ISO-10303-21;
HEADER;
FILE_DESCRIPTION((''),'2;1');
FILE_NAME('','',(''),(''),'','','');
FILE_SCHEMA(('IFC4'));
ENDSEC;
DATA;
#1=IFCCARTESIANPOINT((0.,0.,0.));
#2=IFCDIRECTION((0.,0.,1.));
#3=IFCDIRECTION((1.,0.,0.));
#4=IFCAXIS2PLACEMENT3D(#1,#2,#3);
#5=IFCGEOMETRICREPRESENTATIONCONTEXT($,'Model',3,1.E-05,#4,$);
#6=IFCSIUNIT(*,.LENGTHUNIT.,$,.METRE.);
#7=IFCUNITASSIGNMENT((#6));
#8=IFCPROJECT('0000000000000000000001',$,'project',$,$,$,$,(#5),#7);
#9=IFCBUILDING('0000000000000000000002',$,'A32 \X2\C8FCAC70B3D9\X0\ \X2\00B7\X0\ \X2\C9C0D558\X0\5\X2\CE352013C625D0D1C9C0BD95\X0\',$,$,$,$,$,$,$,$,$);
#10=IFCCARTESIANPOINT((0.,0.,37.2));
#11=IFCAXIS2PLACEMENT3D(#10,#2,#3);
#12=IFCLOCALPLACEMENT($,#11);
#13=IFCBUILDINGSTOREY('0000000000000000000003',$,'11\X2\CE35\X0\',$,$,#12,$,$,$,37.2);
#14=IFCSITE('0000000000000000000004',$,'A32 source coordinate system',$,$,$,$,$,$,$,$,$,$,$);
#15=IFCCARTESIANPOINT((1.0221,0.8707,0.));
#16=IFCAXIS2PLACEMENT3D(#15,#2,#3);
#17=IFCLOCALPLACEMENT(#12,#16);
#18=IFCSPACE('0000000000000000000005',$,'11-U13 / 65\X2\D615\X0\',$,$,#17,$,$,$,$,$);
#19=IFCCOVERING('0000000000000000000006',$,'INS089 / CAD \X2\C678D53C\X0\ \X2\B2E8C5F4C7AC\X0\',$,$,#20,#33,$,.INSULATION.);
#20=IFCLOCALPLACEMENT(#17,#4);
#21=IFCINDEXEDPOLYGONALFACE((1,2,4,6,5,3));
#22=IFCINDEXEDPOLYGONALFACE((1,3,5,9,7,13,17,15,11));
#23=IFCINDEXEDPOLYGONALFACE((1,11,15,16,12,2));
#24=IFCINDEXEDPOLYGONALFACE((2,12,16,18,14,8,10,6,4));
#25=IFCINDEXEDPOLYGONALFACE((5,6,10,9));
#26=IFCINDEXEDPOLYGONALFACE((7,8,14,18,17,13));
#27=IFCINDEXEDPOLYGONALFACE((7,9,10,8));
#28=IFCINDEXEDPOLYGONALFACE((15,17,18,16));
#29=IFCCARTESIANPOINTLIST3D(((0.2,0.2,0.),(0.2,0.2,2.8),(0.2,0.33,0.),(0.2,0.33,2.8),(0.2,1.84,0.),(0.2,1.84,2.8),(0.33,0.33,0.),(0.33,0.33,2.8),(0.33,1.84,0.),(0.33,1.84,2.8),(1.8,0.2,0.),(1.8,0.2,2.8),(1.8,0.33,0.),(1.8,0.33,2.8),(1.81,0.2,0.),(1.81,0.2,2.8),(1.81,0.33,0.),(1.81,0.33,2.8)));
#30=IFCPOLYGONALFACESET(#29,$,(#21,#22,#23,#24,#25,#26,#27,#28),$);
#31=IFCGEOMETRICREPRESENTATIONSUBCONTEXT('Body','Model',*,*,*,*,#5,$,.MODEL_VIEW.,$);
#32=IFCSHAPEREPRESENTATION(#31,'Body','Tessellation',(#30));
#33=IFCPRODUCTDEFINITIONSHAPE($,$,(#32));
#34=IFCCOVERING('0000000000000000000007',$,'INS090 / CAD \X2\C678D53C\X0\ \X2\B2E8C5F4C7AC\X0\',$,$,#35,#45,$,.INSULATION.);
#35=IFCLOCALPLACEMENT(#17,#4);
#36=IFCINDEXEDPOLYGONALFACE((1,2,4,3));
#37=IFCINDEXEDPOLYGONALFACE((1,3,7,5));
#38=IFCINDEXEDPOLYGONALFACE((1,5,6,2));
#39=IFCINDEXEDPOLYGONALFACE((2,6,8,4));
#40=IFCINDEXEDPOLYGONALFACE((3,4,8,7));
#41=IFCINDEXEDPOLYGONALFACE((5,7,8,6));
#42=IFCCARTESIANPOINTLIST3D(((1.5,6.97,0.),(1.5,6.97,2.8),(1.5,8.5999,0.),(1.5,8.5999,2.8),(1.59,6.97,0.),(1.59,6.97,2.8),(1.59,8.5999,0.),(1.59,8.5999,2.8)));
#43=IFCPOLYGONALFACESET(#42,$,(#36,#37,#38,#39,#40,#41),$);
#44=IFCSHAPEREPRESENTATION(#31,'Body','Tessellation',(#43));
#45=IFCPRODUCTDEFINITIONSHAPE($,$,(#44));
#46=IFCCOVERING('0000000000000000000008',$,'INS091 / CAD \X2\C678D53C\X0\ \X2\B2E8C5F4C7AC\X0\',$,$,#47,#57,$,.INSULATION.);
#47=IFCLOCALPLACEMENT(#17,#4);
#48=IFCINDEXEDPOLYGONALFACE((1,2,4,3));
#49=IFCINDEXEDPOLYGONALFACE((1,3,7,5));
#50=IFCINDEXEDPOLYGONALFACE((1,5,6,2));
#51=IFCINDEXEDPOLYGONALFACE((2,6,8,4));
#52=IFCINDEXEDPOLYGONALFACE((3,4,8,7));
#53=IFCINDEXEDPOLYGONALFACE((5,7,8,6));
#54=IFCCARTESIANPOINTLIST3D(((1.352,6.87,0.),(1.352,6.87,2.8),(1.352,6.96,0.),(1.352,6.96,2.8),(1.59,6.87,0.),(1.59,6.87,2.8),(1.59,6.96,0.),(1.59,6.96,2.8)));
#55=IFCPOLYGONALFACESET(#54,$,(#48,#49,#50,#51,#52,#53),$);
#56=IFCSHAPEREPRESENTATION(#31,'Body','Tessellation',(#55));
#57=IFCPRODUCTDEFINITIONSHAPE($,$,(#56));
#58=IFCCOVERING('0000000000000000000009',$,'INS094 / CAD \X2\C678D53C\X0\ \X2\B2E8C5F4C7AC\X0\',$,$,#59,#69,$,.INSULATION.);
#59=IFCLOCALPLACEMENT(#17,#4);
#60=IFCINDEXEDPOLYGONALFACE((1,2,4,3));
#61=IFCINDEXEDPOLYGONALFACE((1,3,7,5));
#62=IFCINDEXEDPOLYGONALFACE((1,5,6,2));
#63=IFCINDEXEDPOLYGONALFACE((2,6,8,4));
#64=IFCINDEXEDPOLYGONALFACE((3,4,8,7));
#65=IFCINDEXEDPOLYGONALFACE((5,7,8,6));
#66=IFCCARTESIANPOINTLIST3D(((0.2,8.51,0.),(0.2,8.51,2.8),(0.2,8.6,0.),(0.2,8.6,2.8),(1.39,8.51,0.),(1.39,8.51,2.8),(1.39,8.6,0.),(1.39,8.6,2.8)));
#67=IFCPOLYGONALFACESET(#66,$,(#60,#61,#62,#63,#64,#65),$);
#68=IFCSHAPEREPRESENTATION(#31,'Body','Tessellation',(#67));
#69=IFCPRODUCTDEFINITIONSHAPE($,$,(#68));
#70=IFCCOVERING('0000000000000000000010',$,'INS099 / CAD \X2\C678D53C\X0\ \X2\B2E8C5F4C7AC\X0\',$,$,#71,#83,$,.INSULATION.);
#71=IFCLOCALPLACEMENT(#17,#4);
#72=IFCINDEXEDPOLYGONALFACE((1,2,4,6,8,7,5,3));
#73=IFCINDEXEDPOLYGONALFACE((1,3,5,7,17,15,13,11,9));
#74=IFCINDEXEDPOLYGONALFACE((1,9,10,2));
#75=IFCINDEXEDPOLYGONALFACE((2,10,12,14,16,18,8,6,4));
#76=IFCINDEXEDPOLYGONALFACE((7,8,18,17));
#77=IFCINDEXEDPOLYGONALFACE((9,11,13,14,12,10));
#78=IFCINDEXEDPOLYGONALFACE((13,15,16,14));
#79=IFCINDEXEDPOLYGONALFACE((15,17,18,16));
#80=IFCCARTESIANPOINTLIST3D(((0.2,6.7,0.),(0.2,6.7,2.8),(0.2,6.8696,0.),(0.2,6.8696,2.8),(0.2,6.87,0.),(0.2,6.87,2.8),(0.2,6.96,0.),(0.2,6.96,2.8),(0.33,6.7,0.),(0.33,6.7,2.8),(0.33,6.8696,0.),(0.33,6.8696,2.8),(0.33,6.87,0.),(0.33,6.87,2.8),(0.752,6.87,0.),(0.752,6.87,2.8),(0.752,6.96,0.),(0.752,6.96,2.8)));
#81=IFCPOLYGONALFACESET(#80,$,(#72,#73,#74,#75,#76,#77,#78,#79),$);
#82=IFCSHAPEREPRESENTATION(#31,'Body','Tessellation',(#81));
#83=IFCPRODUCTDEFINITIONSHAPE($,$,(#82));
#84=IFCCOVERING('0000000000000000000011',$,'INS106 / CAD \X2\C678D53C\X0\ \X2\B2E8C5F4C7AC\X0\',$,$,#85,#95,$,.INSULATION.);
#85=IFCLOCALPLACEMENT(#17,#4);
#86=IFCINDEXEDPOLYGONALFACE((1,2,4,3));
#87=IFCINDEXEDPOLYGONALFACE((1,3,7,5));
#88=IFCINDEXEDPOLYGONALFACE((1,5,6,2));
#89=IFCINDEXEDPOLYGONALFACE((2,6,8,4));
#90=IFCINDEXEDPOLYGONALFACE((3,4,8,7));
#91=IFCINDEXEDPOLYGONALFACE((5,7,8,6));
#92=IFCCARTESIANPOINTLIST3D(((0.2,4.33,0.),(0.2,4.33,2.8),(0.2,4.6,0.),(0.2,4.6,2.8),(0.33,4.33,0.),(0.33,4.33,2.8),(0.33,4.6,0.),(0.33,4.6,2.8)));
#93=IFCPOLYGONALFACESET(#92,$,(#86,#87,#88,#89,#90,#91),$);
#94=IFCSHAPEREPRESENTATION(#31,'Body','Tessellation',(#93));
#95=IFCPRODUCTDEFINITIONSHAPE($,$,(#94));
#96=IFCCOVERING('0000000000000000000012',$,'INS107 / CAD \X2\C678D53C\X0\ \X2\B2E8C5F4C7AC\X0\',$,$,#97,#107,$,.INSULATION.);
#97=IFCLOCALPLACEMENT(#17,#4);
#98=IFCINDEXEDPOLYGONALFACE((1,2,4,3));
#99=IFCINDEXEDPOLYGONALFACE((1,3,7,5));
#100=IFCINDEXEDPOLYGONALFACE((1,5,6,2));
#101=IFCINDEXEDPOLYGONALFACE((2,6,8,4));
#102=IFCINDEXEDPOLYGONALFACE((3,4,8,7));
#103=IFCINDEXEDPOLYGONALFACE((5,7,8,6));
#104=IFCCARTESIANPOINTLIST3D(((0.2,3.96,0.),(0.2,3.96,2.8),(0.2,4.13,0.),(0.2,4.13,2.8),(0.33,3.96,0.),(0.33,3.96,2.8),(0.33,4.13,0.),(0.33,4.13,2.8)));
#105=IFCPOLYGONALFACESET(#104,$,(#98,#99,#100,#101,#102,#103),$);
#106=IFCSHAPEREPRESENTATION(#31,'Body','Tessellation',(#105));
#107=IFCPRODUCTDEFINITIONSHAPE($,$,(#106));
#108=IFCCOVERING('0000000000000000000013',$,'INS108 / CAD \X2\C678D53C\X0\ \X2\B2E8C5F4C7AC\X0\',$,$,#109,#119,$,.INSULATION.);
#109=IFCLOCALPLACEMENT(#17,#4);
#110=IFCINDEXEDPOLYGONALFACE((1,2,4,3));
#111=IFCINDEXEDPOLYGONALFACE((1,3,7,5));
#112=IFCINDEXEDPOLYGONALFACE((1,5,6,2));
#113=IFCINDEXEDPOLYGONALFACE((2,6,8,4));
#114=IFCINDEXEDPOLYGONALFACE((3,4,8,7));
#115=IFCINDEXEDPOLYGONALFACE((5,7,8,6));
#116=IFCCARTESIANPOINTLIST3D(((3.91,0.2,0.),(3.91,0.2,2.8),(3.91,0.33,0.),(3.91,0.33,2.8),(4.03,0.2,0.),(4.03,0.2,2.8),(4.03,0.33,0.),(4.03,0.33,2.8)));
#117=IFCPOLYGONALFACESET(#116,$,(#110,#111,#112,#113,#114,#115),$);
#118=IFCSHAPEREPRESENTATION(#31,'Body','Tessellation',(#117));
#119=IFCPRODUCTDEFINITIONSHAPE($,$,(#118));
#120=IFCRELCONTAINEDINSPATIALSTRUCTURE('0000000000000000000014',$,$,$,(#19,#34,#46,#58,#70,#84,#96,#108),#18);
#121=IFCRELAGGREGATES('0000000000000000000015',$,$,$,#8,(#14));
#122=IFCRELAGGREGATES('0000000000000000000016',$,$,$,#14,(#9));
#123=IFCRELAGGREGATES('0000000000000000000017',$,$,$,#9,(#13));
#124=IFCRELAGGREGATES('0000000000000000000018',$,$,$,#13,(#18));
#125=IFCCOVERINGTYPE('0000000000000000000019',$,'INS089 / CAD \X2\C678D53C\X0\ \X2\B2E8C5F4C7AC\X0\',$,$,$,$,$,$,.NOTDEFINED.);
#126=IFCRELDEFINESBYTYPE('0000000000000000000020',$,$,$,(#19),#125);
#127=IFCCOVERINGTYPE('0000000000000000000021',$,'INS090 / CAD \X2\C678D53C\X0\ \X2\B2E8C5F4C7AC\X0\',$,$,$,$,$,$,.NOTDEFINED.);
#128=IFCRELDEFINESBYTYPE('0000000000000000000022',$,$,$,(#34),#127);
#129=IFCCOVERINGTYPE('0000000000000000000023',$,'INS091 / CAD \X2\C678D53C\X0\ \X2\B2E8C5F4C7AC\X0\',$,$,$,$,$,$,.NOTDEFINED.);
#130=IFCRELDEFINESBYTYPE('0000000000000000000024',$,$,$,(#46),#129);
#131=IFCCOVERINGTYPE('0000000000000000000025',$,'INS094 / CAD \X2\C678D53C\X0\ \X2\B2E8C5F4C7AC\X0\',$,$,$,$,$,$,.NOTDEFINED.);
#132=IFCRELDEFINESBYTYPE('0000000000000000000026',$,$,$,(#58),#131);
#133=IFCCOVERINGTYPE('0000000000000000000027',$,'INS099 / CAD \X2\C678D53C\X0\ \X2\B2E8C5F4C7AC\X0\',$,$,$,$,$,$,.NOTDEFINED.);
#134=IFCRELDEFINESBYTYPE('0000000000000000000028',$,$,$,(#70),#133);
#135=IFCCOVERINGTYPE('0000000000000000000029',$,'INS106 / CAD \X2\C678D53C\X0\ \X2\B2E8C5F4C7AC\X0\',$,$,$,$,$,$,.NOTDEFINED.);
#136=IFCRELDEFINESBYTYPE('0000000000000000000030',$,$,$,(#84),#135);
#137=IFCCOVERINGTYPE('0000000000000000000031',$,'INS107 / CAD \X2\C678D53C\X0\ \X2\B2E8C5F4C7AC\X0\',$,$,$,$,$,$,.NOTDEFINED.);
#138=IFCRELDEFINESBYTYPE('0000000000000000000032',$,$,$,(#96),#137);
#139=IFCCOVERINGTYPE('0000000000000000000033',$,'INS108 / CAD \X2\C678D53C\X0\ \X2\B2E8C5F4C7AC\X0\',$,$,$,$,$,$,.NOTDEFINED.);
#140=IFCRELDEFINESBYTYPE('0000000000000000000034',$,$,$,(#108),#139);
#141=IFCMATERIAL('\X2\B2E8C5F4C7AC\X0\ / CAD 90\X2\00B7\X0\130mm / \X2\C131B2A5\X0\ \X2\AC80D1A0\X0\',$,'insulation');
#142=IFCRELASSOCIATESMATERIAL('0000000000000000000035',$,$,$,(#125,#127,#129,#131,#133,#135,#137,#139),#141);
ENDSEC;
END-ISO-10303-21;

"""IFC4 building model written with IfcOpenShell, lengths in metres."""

from ifc_helpers import new_model, si_unit, frame, origin, origin_with_axes, place, context, subcontext, project, spatial, polyline, outline, extrude, source, transform, mapped, material, type_object, type_shapes, element, save


model = new_model("IFC4")

# Units and contexts
model_context = context("Model", 3, precision=1e-05, world=origin_with_axes())
body_context = subcontext(model_context, "Body", "Model", "MODEL_VIEW")
ifc_project = project(units=[si_unit("LENGTHUNIT", "METRE")], contexts=[model_context])

# Site, building, storey
site = spatial("IfcSite", under=ifc_project, Name="A32 source coordinate system")
building = spatial("IfcBuilding", under=site, Name="A32 주거동 · 지하5층–옥탑지붕")
storey_placement = place(None, frame((0.0, 0.0, 37.2), z_axis=(0.0, 0.0, 1.0), x_axis=(1.0, 0.0, 0.0)))
storey = spatial("IfcBuildingStorey", under=building, at=storey_placement, Name="11층", Elevation=37.2)

# Shared definitions
space_placement = place(storey_placement, frame((1.0221, 0.8707, 0.0), z_axis=(0.0, 0.0, 1.0), x_axis=(1.0, 0.0, 0.0)))
space = spatial("IfcSpace", under=storey, at=space_placement, Name="11-U13 / 65형")

# Coverings
ifc_material = material(Name="단열재 / CAD 90·130mm / 성능 검토", Category="insulation")
covering_type_1 = type_object("IfcCoveringType", Name="INS089 / CAD 외피 단열재", PredefinedType="NOTDEFINED", material=ifc_material)
shared_shape_1 = source(origin(), body_context, "Body", "SweptSolid", [
    extrude(outline(polyline([(0.2, 0.33), (0.2, 1.84), (0.33, 1.84), (0.33, 0.33), (1.8, 0.33), (1.81, 0.33), (1.81, 0.2), (1.8, 0.2), (0.2, 0.2), (0.2, 0.33)])), origin(), (0.0, 0.0, 1.0), 2.8),
])
type_shapes(covering_type_1, [shared_shape_1])
covering_1_placement = place(space_placement, origin_with_axes())
element("IfcCovering", 1, at=covering_1_placement, inside=space, type_object=covering_type_1, Name="INS089 / CAD 외피 단열재", PredefinedType="INSULATION", context=body_context, shape_type="MappedRepresentation", body=[
    mapped(shared_shape_1, transform((0.0, 0.0, 0.0), scale=1.0)),
])
covering_type_2 = type_object("IfcCoveringType", Name="INS090 / CAD 외피 단열재", PredefinedType="NOTDEFINED", material=ifc_material)
shared_shape_2 = source(origin(), body_context, "Body", "SweptSolid", [
    extrude(outline(polyline([(1.59, 6.97), (1.5, 6.97), (1.5, 8.5999), (1.59, 8.5999), (1.59, 6.97)])), origin(), (0.0, 0.0, 1.0), 2.8),
])
type_shapes(covering_type_2, [shared_shape_2])
covering_2_placement = place(space_placement, origin_with_axes())
element("IfcCovering", 2, at=covering_2_placement, inside=space, type_object=covering_type_2, Name="INS090 / CAD 외피 단열재", PredefinedType="INSULATION", context=body_context, shape_type="MappedRepresentation", body=[
    mapped(shared_shape_2, transform((0.0, 0.0, 0.0), scale=1.0)),
])
covering_type_3 = type_object("IfcCoveringType", Name="INS091 / CAD 외피 단열재", PredefinedType="NOTDEFINED", material=ifc_material)
shared_shape_3 = source(origin(), body_context, "Body", "SweptSolid", [
    extrude(outline(polyline([(1.59, 6.96), (1.59, 6.87), (1.352, 6.87), (1.352, 6.96), (1.59, 6.96)])), origin(), (0.0, 0.0, 1.0), 2.8),
])
type_shapes(covering_type_3, [shared_shape_3])
covering_3_placement = place(space_placement, origin_with_axes())
element("IfcCovering", 3, at=covering_3_placement, inside=space, type_object=covering_type_3, Name="INS091 / CAD 외피 단열재", PredefinedType="INSULATION", context=body_context, shape_type="MappedRepresentation", body=[
    mapped(shared_shape_3, transform((0.0, 0.0, 0.0), scale=1.0)),
])
covering_type_4 = type_object("IfcCoveringType", Name="INS094 / CAD 외피 단열재", PredefinedType="NOTDEFINED", material=ifc_material)
shared_shape_4 = source(origin(), body_context, "Body", "SweptSolid", [
    extrude(outline(polyline([(1.39, 8.51), (0.2, 8.51), (0.2, 8.6), (1.39, 8.6), (1.39, 8.51)])), origin(), (0.0, 0.0, 1.0), 2.8),
])
type_shapes(covering_type_4, [shared_shape_4])
covering_4_placement = place(space_placement, origin_with_axes())
element("IfcCovering", 4, at=covering_4_placement, inside=space, type_object=covering_type_4, Name="INS094 / CAD 외피 단열재", PredefinedType="INSULATION", context=body_context, shape_type="MappedRepresentation", body=[
    mapped(shared_shape_4, transform((0.0, 0.0, 0.0), scale=1.0)),
])
covering_type_5 = type_object("IfcCoveringType", Name="INS099 / CAD 외피 단열재", PredefinedType="NOTDEFINED", material=ifc_material)
shared_shape_5 = source(origin(), body_context, "Body", "SweptSolid", [
    extrude(outline(polyline([(0.2, 6.8696), (0.2, 6.87), (0.2, 6.96), (0.752, 6.96), (0.752, 6.87), (0.33, 6.87), (0.33, 6.8696), (0.33, 6.7), (0.2, 6.7), (0.2, 6.8696)])), origin(), (0.0, 0.0, 1.0), 2.8),
])
type_shapes(covering_type_5, [shared_shape_5])
covering_5_placement = place(space_placement, origin_with_axes())
element("IfcCovering", 5, at=covering_5_placement, inside=space, type_object=covering_type_5, Name="INS099 / CAD 외피 단열재", PredefinedType="INSULATION", context=body_context, shape_type="MappedRepresentation", body=[
    mapped(shared_shape_5, transform((0.0, 0.0, 0.0), scale=1.0)),
])
covering_type_6 = type_object("IfcCoveringType", Name="INS106 / CAD 외피 단열재", PredefinedType="NOTDEFINED", material=ifc_material)
shared_shape_6 = source(origin(), body_context, "Body", "SweptSolid", [
    extrude(outline(polyline([(0.33, 4.6), (0.33, 4.33), (0.2, 4.33), (0.2, 4.6), (0.33, 4.6)])), origin(), (0.0, 0.0, 1.0), 2.8),
])
type_shapes(covering_type_6, [shared_shape_6])
covering_6_placement = place(space_placement, origin_with_axes())
element("IfcCovering", 6, at=covering_6_placement, inside=space, type_object=covering_type_6, Name="INS106 / CAD 외피 단열재", PredefinedType="INSULATION", context=body_context, shape_type="MappedRepresentation", body=[
    mapped(shared_shape_6, transform((0.0, 0.0, 0.0), scale=1.0)),
])
covering_type_7 = type_object("IfcCoveringType", Name="INS107 / CAD 외피 단열재", PredefinedType="NOTDEFINED", material=ifc_material)
shared_shape_7 = source(origin(), body_context, "Body", "SweptSolid", [
    extrude(outline(polyline([(0.33, 3.96), (0.2, 3.96), (0.2, 4.13), (0.33, 4.13), (0.33, 3.96)])), origin(), (0.0, 0.0, 1.0), 2.8),
])
type_shapes(covering_type_7, [shared_shape_7])
covering_7_placement = place(space_placement, origin_with_axes())
element("IfcCovering", 7, at=covering_7_placement, inside=space, type_object=covering_type_7, Name="INS107 / CAD 외피 단열재", PredefinedType="INSULATION", context=body_context, shape_type="MappedRepresentation", body=[
    mapped(shared_shape_7, transform((0.0, 0.0, 0.0), scale=1.0)),
])
covering_type_8 = type_object("IfcCoveringType", Name="INS108 / CAD 외피 단열재", PredefinedType="NOTDEFINED", material=ifc_material)
shared_shape_8 = source(origin(), body_context, "Body", "SweptSolid", [
    extrude(outline(polyline([(4.03, 0.2), (3.91, 0.2), (3.91, 0.33), (4.03, 0.33), (4.03, 0.2)])), origin(), (0.0, 0.0, 1.0), 2.8),
])
type_shapes(covering_type_8, [shared_shape_8])
covering_8_placement = place(space_placement, origin_with_axes())
element("IfcCovering", 8, at=covering_8_placement, inside=space, type_object=covering_type_8, Name="INS108 / CAD 외피 단열재", PredefinedType="INSULATION", context=body_context, shape_type="MappedRepresentation", body=[
    mapped(shared_shape_8, transform((0.0, 0.0, 0.0), scale=1.0)),
])

save(model, "model.ifc")
